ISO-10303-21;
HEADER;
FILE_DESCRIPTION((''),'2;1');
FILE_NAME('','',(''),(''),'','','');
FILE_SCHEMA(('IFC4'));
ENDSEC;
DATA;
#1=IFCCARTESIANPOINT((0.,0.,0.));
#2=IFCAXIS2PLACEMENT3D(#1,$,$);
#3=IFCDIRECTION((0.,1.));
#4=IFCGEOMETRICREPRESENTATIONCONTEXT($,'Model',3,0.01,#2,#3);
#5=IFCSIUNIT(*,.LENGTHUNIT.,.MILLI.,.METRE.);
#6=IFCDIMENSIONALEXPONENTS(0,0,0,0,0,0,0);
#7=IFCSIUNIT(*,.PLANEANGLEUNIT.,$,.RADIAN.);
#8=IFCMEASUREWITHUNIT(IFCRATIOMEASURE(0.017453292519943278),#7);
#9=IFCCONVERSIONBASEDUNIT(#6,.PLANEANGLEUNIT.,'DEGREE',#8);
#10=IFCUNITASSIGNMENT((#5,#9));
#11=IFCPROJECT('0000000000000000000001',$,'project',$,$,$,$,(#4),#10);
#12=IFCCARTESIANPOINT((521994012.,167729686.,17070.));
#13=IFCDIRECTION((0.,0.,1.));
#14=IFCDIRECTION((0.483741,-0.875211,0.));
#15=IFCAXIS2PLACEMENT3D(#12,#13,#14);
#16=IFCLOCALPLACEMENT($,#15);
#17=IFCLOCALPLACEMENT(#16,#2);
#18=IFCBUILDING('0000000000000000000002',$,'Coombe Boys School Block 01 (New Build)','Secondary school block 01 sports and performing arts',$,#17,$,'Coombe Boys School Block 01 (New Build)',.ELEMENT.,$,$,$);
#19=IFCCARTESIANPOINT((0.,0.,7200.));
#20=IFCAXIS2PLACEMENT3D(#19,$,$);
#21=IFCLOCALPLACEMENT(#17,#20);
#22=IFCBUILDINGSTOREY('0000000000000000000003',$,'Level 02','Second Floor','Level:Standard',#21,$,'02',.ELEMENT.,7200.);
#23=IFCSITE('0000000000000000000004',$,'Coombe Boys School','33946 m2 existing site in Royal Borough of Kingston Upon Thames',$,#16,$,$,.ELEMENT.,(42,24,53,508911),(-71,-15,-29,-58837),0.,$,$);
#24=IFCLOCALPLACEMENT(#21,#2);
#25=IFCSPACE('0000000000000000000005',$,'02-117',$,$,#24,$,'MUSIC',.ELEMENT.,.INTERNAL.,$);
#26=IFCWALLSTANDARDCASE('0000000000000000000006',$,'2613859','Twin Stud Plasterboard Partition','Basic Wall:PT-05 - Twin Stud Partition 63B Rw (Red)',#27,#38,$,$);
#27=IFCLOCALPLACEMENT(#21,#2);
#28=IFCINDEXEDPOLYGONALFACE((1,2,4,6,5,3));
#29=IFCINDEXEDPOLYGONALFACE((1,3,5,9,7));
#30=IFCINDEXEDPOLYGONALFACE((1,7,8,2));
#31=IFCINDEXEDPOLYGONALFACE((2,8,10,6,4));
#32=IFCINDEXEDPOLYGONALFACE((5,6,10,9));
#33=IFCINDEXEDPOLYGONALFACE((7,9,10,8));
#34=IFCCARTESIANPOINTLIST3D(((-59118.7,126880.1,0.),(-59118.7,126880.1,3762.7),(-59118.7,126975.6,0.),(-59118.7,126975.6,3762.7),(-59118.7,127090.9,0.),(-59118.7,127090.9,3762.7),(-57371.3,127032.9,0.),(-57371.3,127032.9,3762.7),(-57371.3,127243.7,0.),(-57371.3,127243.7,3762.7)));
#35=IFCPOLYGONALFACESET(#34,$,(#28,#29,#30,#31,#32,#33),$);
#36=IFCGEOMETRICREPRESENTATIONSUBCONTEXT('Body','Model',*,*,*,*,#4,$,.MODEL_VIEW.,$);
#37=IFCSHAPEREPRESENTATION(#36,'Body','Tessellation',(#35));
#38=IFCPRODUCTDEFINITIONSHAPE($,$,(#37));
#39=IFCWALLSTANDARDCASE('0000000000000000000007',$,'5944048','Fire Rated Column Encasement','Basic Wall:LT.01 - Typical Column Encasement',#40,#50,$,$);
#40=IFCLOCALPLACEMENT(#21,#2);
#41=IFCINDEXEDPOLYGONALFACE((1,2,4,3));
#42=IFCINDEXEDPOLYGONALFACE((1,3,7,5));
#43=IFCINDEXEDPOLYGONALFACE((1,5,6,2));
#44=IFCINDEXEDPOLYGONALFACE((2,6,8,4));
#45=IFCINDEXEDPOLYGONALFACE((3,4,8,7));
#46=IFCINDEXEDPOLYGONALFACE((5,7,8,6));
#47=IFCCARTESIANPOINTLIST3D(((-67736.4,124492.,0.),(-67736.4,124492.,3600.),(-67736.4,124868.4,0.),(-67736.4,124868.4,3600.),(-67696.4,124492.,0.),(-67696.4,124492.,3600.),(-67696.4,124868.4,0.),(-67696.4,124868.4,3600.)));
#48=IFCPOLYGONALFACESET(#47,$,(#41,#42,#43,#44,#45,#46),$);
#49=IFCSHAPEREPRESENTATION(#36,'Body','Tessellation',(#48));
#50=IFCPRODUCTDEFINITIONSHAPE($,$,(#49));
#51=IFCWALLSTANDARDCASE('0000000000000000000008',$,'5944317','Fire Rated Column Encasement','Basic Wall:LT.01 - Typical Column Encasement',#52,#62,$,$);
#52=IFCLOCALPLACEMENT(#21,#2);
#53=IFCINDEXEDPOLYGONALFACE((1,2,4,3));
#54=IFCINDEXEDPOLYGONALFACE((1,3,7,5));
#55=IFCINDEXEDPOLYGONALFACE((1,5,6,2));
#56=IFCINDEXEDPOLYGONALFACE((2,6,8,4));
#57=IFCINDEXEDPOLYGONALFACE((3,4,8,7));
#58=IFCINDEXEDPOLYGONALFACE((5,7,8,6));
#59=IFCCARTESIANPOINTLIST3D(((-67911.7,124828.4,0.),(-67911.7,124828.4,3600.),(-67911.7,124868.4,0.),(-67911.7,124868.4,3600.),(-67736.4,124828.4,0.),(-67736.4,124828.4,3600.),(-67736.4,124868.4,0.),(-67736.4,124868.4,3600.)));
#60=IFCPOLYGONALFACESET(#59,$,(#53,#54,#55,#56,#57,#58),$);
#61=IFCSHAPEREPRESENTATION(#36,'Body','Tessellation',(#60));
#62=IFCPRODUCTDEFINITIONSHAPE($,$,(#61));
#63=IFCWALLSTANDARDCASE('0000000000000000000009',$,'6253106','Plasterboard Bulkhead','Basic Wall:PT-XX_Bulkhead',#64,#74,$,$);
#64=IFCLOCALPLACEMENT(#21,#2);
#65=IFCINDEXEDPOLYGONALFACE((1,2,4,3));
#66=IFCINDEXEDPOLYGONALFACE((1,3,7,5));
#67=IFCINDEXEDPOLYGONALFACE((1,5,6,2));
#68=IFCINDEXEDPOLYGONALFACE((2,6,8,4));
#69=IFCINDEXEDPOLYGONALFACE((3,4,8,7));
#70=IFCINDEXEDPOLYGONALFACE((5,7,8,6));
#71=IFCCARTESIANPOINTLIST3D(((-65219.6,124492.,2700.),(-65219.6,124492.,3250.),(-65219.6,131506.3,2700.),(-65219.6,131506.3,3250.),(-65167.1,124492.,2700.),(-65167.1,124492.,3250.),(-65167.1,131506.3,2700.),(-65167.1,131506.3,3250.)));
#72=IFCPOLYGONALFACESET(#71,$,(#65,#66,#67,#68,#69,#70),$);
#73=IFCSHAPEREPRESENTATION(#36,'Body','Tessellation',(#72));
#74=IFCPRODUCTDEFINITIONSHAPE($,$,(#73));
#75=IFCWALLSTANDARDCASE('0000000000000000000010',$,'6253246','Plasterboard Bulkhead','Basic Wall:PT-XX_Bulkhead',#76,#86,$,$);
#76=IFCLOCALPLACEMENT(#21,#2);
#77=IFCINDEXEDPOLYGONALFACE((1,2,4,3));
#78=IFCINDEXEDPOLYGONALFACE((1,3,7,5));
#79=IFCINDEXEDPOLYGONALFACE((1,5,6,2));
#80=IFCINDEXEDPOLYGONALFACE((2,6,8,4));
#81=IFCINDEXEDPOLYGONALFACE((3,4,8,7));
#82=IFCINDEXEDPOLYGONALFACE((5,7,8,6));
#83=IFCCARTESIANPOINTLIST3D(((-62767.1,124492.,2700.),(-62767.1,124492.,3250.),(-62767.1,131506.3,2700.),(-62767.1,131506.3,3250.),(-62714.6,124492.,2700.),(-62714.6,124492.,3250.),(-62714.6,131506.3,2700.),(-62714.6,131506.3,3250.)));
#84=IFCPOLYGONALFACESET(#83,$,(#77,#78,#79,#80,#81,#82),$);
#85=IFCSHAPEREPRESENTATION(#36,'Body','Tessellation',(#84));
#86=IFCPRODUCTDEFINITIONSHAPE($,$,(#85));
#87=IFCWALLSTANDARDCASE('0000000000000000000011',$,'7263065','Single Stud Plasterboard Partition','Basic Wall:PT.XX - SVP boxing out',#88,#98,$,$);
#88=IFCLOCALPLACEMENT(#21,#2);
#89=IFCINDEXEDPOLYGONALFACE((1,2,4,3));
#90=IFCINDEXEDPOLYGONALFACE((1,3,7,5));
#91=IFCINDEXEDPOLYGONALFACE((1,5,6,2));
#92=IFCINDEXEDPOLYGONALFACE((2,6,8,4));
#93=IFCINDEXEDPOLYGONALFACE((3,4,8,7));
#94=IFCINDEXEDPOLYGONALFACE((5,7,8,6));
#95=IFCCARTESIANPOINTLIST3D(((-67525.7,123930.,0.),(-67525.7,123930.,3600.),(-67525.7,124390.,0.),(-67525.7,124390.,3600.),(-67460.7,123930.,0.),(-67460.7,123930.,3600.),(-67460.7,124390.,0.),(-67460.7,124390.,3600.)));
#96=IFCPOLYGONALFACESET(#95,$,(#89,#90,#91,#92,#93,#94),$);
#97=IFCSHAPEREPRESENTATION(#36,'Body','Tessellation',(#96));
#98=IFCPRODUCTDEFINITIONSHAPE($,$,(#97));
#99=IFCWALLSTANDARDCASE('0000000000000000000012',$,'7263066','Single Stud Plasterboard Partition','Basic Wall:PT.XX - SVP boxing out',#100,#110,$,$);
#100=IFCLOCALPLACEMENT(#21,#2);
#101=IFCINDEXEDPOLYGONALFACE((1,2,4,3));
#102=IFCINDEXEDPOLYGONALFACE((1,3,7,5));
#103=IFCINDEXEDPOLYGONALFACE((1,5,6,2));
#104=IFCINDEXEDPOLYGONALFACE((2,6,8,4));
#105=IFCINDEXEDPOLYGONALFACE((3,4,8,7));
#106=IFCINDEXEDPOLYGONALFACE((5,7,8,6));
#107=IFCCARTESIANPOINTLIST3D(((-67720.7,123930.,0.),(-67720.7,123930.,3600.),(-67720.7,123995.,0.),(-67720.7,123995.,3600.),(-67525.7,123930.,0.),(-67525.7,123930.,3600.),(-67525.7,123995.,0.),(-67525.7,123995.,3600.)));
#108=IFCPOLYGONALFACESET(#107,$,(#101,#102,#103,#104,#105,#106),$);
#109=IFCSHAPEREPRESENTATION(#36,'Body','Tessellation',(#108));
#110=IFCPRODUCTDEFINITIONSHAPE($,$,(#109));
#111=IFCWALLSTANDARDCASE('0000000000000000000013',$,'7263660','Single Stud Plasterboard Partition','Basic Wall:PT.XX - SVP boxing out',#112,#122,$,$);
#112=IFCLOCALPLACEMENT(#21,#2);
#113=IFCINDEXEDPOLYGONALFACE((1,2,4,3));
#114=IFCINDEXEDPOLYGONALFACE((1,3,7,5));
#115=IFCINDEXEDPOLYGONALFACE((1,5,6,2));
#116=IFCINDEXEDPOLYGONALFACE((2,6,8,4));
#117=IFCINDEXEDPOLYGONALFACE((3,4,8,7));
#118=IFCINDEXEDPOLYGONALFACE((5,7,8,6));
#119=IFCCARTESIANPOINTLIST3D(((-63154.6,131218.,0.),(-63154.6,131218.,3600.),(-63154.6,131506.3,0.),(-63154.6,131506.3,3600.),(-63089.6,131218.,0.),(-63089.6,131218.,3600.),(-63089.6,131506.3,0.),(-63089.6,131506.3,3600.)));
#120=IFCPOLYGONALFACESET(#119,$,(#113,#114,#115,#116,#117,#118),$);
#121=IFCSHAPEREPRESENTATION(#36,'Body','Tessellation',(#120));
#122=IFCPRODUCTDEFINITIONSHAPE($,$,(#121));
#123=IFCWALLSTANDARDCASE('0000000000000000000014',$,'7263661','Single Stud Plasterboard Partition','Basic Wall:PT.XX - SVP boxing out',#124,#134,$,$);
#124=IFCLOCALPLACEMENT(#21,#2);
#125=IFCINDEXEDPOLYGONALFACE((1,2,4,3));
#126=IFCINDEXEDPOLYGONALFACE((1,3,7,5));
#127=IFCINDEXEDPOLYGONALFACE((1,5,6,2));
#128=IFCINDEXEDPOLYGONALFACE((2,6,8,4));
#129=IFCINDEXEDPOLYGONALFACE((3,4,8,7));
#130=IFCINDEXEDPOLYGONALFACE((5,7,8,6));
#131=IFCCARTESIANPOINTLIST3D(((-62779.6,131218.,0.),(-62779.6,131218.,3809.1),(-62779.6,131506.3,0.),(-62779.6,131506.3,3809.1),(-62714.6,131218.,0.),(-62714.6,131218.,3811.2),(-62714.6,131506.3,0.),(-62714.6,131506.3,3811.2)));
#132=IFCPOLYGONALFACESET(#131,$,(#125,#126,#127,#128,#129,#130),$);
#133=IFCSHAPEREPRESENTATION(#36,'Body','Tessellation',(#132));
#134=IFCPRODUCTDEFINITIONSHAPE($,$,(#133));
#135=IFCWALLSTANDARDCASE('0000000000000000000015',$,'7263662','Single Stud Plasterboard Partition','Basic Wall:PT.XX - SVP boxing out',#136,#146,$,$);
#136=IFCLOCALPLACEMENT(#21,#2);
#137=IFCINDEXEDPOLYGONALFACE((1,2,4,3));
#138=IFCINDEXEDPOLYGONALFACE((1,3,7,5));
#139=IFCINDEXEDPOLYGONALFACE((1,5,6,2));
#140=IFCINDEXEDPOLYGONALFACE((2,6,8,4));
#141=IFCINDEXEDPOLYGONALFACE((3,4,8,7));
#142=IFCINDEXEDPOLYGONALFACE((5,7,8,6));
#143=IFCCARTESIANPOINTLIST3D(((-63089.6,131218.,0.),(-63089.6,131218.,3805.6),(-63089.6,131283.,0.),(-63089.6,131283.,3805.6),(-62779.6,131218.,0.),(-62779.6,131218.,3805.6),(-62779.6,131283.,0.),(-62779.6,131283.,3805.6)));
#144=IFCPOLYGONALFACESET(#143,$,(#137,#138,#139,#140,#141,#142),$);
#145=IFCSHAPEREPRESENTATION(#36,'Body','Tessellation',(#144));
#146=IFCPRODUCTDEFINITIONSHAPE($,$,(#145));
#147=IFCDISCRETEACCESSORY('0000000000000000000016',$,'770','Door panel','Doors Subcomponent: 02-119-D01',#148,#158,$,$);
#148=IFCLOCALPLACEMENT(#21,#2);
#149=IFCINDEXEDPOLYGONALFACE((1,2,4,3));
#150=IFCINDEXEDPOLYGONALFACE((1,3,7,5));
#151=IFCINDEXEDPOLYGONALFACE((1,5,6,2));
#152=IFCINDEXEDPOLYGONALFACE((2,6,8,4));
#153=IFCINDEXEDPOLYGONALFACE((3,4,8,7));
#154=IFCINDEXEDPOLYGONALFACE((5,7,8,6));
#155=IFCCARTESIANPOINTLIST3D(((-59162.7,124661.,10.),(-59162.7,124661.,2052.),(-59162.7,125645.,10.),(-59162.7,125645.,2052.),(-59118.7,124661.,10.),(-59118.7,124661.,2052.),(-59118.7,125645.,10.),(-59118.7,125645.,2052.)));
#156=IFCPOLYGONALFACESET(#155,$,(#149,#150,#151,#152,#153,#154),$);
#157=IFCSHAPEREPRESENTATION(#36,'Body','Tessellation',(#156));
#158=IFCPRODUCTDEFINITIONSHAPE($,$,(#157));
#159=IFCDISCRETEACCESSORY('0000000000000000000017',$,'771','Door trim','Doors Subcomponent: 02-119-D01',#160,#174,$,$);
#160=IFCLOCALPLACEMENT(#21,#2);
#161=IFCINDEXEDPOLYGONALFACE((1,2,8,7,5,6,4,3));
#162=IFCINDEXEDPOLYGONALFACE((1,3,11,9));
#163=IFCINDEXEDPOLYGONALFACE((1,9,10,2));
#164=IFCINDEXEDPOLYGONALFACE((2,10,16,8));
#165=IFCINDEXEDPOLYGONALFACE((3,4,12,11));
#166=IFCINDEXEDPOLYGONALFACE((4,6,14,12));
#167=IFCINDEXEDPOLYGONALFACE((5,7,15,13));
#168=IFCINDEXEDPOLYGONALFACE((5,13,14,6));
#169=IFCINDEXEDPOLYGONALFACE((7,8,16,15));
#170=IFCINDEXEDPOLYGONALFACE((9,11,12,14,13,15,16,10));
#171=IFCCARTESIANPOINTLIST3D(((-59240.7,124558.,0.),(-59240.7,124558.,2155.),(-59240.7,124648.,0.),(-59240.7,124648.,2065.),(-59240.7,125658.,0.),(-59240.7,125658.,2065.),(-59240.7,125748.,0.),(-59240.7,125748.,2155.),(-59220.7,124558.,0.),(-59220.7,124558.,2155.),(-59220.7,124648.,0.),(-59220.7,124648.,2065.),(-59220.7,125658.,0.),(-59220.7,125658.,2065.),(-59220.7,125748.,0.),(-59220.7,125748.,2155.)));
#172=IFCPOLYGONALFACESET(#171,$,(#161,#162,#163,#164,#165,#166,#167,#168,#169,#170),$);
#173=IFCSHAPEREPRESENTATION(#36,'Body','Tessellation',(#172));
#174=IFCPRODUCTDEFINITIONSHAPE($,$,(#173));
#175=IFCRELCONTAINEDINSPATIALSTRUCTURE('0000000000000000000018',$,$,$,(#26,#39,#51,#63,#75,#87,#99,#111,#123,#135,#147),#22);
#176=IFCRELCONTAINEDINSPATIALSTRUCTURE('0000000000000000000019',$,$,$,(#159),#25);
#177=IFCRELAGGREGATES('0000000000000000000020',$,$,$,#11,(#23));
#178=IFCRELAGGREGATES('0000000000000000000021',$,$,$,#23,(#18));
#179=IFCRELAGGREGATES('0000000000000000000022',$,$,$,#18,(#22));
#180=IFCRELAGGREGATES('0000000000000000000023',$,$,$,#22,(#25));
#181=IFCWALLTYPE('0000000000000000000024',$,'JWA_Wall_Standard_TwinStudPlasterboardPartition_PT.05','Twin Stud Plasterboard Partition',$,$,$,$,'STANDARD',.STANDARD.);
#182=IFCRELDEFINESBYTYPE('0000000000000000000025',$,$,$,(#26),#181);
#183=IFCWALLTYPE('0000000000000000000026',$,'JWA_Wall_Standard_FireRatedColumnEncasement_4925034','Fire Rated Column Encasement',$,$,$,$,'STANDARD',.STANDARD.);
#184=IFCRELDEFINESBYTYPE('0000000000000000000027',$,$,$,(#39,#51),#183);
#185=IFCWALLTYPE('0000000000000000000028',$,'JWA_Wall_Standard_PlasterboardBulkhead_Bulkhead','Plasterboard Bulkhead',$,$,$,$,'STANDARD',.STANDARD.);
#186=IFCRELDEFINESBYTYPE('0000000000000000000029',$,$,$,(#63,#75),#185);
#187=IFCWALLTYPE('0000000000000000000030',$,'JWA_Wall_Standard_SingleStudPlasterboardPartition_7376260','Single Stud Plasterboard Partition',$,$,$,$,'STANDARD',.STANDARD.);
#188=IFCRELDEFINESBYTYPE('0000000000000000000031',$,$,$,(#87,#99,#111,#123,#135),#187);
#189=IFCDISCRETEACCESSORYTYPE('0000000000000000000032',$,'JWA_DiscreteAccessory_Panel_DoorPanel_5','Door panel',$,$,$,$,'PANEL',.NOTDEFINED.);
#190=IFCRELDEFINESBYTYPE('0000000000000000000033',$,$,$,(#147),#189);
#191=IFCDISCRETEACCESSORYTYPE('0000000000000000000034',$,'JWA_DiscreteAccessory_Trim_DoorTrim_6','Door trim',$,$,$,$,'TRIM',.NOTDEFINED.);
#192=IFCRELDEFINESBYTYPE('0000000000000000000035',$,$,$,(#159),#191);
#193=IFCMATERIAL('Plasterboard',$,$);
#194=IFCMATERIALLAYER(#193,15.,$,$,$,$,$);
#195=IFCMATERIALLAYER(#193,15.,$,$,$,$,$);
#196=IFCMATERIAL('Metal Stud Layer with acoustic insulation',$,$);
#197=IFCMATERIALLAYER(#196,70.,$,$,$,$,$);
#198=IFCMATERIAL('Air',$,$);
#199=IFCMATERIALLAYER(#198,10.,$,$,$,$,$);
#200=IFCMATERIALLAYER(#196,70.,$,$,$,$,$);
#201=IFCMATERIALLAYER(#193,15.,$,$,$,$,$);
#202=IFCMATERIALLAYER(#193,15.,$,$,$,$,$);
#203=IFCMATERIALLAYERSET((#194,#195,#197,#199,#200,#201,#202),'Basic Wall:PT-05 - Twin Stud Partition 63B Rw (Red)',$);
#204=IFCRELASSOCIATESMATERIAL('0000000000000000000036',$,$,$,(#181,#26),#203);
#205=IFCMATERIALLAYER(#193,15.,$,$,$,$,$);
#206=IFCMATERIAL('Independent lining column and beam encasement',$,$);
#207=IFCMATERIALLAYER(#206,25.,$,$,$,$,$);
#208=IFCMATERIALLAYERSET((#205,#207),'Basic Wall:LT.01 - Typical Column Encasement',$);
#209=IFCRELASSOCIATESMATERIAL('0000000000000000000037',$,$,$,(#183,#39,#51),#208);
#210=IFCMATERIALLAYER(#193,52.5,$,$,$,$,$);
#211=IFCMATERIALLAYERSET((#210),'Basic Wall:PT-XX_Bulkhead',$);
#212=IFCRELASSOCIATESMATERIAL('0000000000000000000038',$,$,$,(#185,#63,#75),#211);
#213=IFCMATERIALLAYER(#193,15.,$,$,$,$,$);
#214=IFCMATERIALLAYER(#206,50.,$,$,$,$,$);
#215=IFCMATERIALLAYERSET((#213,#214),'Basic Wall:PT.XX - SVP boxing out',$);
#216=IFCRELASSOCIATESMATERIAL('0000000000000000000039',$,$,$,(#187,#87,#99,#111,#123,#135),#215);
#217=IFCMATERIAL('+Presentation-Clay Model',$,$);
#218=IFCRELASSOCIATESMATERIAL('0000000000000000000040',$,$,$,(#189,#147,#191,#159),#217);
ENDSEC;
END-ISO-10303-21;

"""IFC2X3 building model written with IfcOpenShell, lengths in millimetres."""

from ifc_helpers import new_model, entity, si_unit, converted_unit, direction, frame, frame_2d, origin, origin_2d_with_axis, place, context, subcontext, project, spatial, polyline, rectangle, outline, extrude, clip, bounded_halfspace, source, transform, mapped, material, layer, layer_set, layer_usage, type_object, type_shapes, element, save


model = new_model("IFC2X3")

# Units and contexts
model_context = context("Model", 3, precision=0.01, world=origin(), true_north=direction((0.0, 1.0)))
body_context = subcontext(model_context, "Body", "Model", "MODEL_VIEW")
ifc_project = project(units=[si_unit("LENGTHUNIT", "METRE", prefix="MILLI"), converted_unit("PLANEANGLEUNIT", "DEGREE", entity("IfcRatioMeasure", 0.017453292519943278), si_unit("PLANEANGLEUNIT", "RADIAN"), dimensions=[0, 0, 0, 0, 0, 0, 0])], contexts=[model_context])

# Site, building, storey
site_placement = place(None, frame((521994012.0, 167729686.0, 17070.0), z_axis=(0.0, 0.0, 1.0), x_axis=(0.483741, -0.875211, 0.0)))
site = spatial("IfcSite", under=ifc_project, at=site_placement, Name="Coombe Boys School", Description="33946 m2 existing site in Royal Borough of Kingston Upon Thames", CompositionType="ELEMENT", RefLatitude=(42, 24, 53, 508911), RefLongitude=(-71, -15, -29, -58837), RefElevation=0.0)
building_placement = place(site_placement, origin())
building = spatial("IfcBuilding", under=site, at=building_placement, Name="Coombe Boys School Block 01 (New Build)", Description="Secondary school block 01 sports and performing arts", LongName="Coombe Boys School Block 01 (New Build)", CompositionType="ELEMENT")
storey_placement = place(building_placement, frame((0.0, 0.0, 7200.0)))
storey = spatial("IfcBuildingStorey", under=building, at=storey_placement, Name="Level 02", Description="Second Floor", ObjectType="Level:Standard", LongName="02", CompositionType="ELEMENT", Elevation=7200.0)

# Shared definitions
ifc_material_1 = material(Name="Plasterboard")

# Shared definitions
ifc_material_2 = material(Name="Air")

# Walls
ifc_layer_1 = layer(ifc_material_1, 15.0)
ifc_layer_2 = layer(ifc_material_1, 15.0)
ifc_material_3 = material(Name="Metal Stud Layer with acoustic insulation")
ifc_layer_3 = layer(ifc_material_3, 70.0)
ifc_layer_4 = layer(ifc_material_2, 10.0)
ifc_layer_5 = layer(ifc_material_3, 70.0)
ifc_layer_6 = layer(ifc_material_1, 15.0)
ifc_layer_7 = layer(ifc_material_1, 15.0)
ifc_layer_set_1 = layer_set([ifc_layer_1, ifc_layer_2, ifc_layer_3, ifc_layer_4, ifc_layer_5, ifc_layer_6, ifc_layer_7], Name="Basic Wall:PT-05 - Twin Stud Partition 63B Rw (Red)")
ifc_layer_usage_1 = layer_usage(ifc_layer_set_1, "AXIS2", "NEGATIVE", 105.0)
wall_type_1 = type_object("IfcWallType", Name="JWA_Wall_Standard_TwinStudPlasterboardPartition_PT.05", Description="Twin Stud Plasterboard Partition", ElementType="STANDARD", PredefinedType="STANDARD", material=ifc_layer_set_1)
wall_1_placement = place(storey_placement, frame((-59127.9, 126984.7, 0.0), z_axis=(0.0, 0.0, 1.0), x_axis=(0.996195, 0.087156, 0.0)))
element("IfcWallStandardCase", 1, at=wall_1_placement, inside=storey, type_object=wall_type_1, material=ifc_layer_usage_1, Name="2613859", Description="Twin Stud Plasterboard Partition", ObjectType="Basic Wall:PT-05 - Twin Stud Partition 63B Rw (Red)", context=body_context, shape_type="SweptSolid", body=[
    extrude(outline(polyline([(1754.1, -105.0), (1772.4, 105.0), (18.4, 105.0), (8.3, -9.8), (0.0, -105.0), (1754.1, -105.0)])), origin(), (0.0, 0.0, 1.0), 3762.7),
])
ifc_layer_8 = layer(ifc_material_1, 15.0)
ifc_material_4 = material(Name="Independent lining column and beam encasement")
ifc_layer_9 = layer(ifc_material_4, 25.0)
ifc_layer_set_2 = layer_set([ifc_layer_8, ifc_layer_9], Name="Basic Wall:LT.01 - Typical Column Encasement")
ifc_layer_usage_2 = layer_usage(ifc_layer_set_2, "AXIS2", "NEGATIVE", 20.0)
wall_type_2 = type_object("IfcWallType", Name="JWA_Wall_Standard_FireRatedColumnEncasement_4925034", Description="Fire Rated Column Encasement", ElementType="STANDARD", PredefinedType="STANDARD", material=ifc_layer_set_2)
wall_2_placement = place(storey_placement, frame((-67716.4, 124868.4, 0.0), z_axis=(0.0, 0.0, 1.0), x_axis=(0.0, -1.0, 0.0)))
element("IfcWallStandardCase", 2, at=wall_2_placement, inside=storey, type_object=wall_type_2, material=ifc_layer_usage_2, Name="5944048", Description="Fire Rated Column Encasement", ObjectType="Basic Wall:LT.01 - Typical Column Encasement", context=body_context, shape_type="SweptSolid", body=[
    extrude(rectangle(XDim=376.4, YDim=40.0, at=frame_2d((188.2, 0.0), x_axis=(-1.0, 0.0))), origin(), (0.0, 0.0, 1.0), 3600.0),
])
wall_3_placement = place(storey_placement, frame((-67911.7, 124848.4, 0.0)))
element("IfcWallStandardCase", 3, at=wall_3_placement, inside=storey, type_object=wall_type_2, material=ifc_layer_usage_2, Name="5944317", Description="Fire Rated Column Encasement", ObjectType="Basic Wall:LT.01 - Typical Column Encasement", context=body_context, shape_type="SweptSolid", body=[
    extrude(rectangle(XDim=175.3, YDim=40.0, at=frame_2d((87.7, 0.0), x_axis=(-1.0, 0.0))), origin(), (0.0, 0.0, 1.0), 3600.0),
])
ifc_layer_10 = layer(ifc_material_1, 52.5)
ifc_layer_set_3 = layer_set([ifc_layer_10], Name="Basic Wall:PT-XX_Bulkhead")
ifc_layer_usage_3 = layer_usage(ifc_layer_set_3, "AXIS2", "NEGATIVE", 26.2)
wall_type_3 = type_object("IfcWallType", Name="JWA_Wall_Standard_PlasterboardBulkhead_Bulkhead", Description="Plasterboard Bulkhead", ElementType="STANDARD", PredefinedType="STANDARD", material=ifc_layer_set_3)
for number, where, z_axis, x_axis, name in (
    (4, (-65193.3, 131506.3, 2700.0), (0.0, 0.0, 1.0), (0.0, -1.0, 0.0), "6253106"),
    (5, (-62740.8, 124492.0, 2700.0), (0.0, 0.0, 1.0), (0.0, 1.0, 0.0), "6253246"),
):
    element("IfcWallStandardCase", number, at=place(storey_placement, frame(where, z_axis=z_axis, x_axis=x_axis)), inside=storey, type_object=wall_type_3, material=ifc_layer_usage_3, Name=name, Description="Plasterboard Bulkhead", ObjectType="Basic Wall:PT-XX_Bulkhead", context=body_context, shape_type="SweptSolid", body=[
        extrude(rectangle(XDim=7014.3, YDim=52.5, at=frame_2d((3507.2, 0.0), x_axis=(-1.0, 0.0))), origin(), (0.0, 0.0, 1.0), 550.0),
    ])
ifc_layer_11 = layer(ifc_material_1, 15.0)
ifc_layer_12 = layer(ifc_material_4, 50.0)
ifc_layer_set_4 = layer_set([ifc_layer_11, ifc_layer_12], Name="Basic Wall:PT.XX - SVP boxing out")
ifc_layer_usage_4 = layer_usage(ifc_layer_set_4, "AXIS2", "NEGATIVE", 32.5)
wall_type_4 = type_object("IfcWallType", Name="JWA_Wall_Standard_SingleStudPlasterboardPartition_7376260", Description="Single Stud Plasterboard Partition", ElementType="STANDARD", PredefinedType="STANDARD", material=ifc_layer_set_4)
wall_4_placement = place(storey_placement, frame((-67493.2, 124390.0, 0.0), z_axis=(0.0, 0.0, 1.0), x_axis=(0.0, -1.0, 0.0)))
element("IfcWallStandardCase", 6, at=wall_4_placement, inside=storey, type_object=wall_type_4, material=ifc_layer_usage_4, Name="7263065", Description="Single Stud Plasterboard Partition", ObjectType="Basic Wall:PT.XX - SVP boxing out", context=body_context, shape_type="SweptSolid", body=[
    extrude(rectangle(XDim=460.0, YDim=65.0, at=frame_2d((230.0, 0.0), x_axis=(-1.0, 0.0))), origin(), (0.0, 0.0, 1.0), 3600.0),
])
wall_5_placement = place(storey_placement, frame((-67525.7, 123962.5, 0.0), z_axis=(0.0, 0.0, 1.0), x_axis=(-1.0, 0.0, 0.0)))
element("IfcWallStandardCase", 7, at=wall_5_placement, inside=storey, type_object=wall_type_4, material=ifc_layer_usage_4, Name="7263066", Description="Single Stud Plasterboard Partition", ObjectType="Basic Wall:PT.XX - SVP boxing out", context=body_context, shape_type="SweptSolid", body=[
    extrude(rectangle(XDim=195.0, YDim=65.0, at=frame_2d((97.5, 0.0), x_axis=(-1.0, 0.0))), origin(), (0.0, 0.0, 1.0), 3600.0),
])
wall_6_placement = place(storey_placement, frame((-63122.1, 131218.0, 0.0), z_axis=(0.0, 0.0, 1.0), x_axis=(0.0, 1.0, 0.0)))
element("IfcWallStandardCase", 8, at=wall_6_placement, inside=storey, type_object=wall_type_4, material=ifc_layer_usage_4, Name="7263660", Description="Single Stud Plasterboard Partition", ObjectType="Basic Wall:PT.XX - SVP boxing out", context=body_context, shape_type="SweptSolid", body=[
    extrude(rectangle(XDim=288.3, YDim=65.0, at=frame_2d((144.2, 0.0), x_axis=(-1.0, 0.0))), origin(), (0.0, 0.0, 1.0), 3600.0),
])
wall_7_placement = place(storey_placement, frame((-62747.1, 131506.3, 0.0), z_axis=(0.0, 0.0, 1.0), x_axis=(0.0, -1.0, 0.0)))
element("IfcWallStandardCase", 9, at=wall_7_placement, inside=storey, type_object=wall_type_4, material=ifc_layer_usage_4, Name="7263661", Description="Single Stud Plasterboard Partition", ObjectType="Basic Wall:PT.XX - SVP boxing out", context=body_context, shape_type="Clipping", body=[
    clip(extrude(rectangle(XDim=288.3, YDim=65.0, at=frame_2d((144.2, 0.0), x_axis=(-1.0, 0.0))), origin(), (0.0, 0.0, 1.0), 3811.2), bounded_halfspace(frame((0.0, -32.5, 3809.1), z_axis=(0.0, -0.032283, 0.999479), x_axis=(1.0, 0.0, 0.0)), False, frame((0.0, -32.5, 3809.1)), polyline([(0.0, 0.0), (288.3, 0.0), (288.3, 65.0), (0.0, 65.0), (0.0, 0.0)]))),
])
wall_8_placement = place(storey_placement, frame((-62779.6, 131250.5, 0.0), z_axis=(0.0, 0.0, 1.0), x_axis=(-1.0, 0.0, 0.0)))
element("IfcWallStandardCase", 10, at=wall_8_placement, inside=storey, type_object=wall_type_4, material=ifc_layer_usage_4, Name="7263662", Description="Single Stud Plasterboard Partition", ObjectType="Basic Wall:PT.XX - SVP boxing out", context=body_context, shape_type="SweptSolid", body=[
    extrude(rectangle(XDim=310.0, YDim=65.0, at=frame_2d((155.0, 0.0), x_axis=(-1.0, 0.0))), origin(), (0.0, 0.0, 1.0), 3805.6),
])

# Shared definitions
ifc_material_5 = material(Name="+Presentation-Clay Model")

# Discrete accessory
discrete_accessory_type_1 = type_object("IfcDiscreteAccessoryType", Name="JWA_DiscreteAccessory_Panel_DoorPanel_5", Description="Door panel", ElementType="PANEL", material=ifc_material_5)
shared_shape_1 = source(origin(), body_context, "Body", "SweptSolid", [
    extrude(rectangle(XDim=44.0, YDim=984.0, at=origin_2d_with_axis()), frame((0.0, 22.0, 10.0), z_axis=(0.0, 0.0, 1.0), x_axis=(0.0, -1.0, 0.0)), (0.0, 0.0, 1.0), 2042.0),
])
type_shapes(discrete_accessory_type_1, [shared_shape_1])
discrete_accessory_1_placement = place(storey_placement, frame((-59162.7, 125153.0, 0.0), z_axis=(0.0, 0.0, 1.0), x_axis=(0.0, -1.0, 0.0)))
element("IfcDiscreteAccessory", 11, at=discrete_accessory_1_placement, inside=storey, type_object=discrete_accessory_type_1, material=ifc_material_5, Name="770", Description="Door panel", ObjectType="Doors Subcomponent: 02-119-D01", context=body_context, shape_type="MappedRepresentation", body=[
    mapped(shared_shape_1, transform((0.0, 0.0, 0.0), scale=1.0)),
])

# Shared definitions
space_1_placement = place(storey_placement, origin())
space_1 = spatial("IfcSpace", under=storey, at=space_1_placement, Name="02-117", LongName="MUSIC", CompositionType="ELEMENT", InteriorOrExteriorSpace="INTERNAL")

# Discrete accessory
discrete_accessory_type_2 = type_object("IfcDiscreteAccessoryType", Name="JWA_DiscreteAccessory_Trim_DoorTrim_6", Description="Door trim", ElementType="TRIM", material=ifc_material_5)
shared_shape_2 = source(origin(), body_context, "Body", "SweptSolid", [
    extrude(outline(polyline([(-1055.0, -595.0), (1100.0, -595.0), (1100.0, 595.0), (-1055.0, 595.0), (-1055.0, 505.0), (1010.0, 505.0), (1010.0, -505.0), (-1055.0, -505.0), (-1055.0, -595.0)])), frame((0.0, -20.0, 1055.0), z_axis=(0.0, 1.0, 0.0), x_axis=(0.0, 0.0, 1.0)), (0.0, 0.0, 1.0), 20.0),
])
type_shapes(discrete_accessory_type_2, [shared_shape_2])
discrete_accessory_2_placement = place(space_1_placement, frame((-59220.7, 125153.0, 0.0), z_axis=(0.0, 0.0, 1.0), x_axis=(0.0, -1.0, 0.0)))
element("IfcDiscreteAccessory", 12, at=discrete_accessory_2_placement, inside=space_1, type_object=discrete_accessory_type_2, material=ifc_material_5, Name="771", Description="Door trim", ObjectType="Doors Subcomponent: 02-119-D01", context=body_context, shape_type="MappedRepresentation", body=[
    mapped(shared_shape_2, transform((0.0, 0.0, 0.0), scale=1.0)),
])

save(model, "model.ifc")
